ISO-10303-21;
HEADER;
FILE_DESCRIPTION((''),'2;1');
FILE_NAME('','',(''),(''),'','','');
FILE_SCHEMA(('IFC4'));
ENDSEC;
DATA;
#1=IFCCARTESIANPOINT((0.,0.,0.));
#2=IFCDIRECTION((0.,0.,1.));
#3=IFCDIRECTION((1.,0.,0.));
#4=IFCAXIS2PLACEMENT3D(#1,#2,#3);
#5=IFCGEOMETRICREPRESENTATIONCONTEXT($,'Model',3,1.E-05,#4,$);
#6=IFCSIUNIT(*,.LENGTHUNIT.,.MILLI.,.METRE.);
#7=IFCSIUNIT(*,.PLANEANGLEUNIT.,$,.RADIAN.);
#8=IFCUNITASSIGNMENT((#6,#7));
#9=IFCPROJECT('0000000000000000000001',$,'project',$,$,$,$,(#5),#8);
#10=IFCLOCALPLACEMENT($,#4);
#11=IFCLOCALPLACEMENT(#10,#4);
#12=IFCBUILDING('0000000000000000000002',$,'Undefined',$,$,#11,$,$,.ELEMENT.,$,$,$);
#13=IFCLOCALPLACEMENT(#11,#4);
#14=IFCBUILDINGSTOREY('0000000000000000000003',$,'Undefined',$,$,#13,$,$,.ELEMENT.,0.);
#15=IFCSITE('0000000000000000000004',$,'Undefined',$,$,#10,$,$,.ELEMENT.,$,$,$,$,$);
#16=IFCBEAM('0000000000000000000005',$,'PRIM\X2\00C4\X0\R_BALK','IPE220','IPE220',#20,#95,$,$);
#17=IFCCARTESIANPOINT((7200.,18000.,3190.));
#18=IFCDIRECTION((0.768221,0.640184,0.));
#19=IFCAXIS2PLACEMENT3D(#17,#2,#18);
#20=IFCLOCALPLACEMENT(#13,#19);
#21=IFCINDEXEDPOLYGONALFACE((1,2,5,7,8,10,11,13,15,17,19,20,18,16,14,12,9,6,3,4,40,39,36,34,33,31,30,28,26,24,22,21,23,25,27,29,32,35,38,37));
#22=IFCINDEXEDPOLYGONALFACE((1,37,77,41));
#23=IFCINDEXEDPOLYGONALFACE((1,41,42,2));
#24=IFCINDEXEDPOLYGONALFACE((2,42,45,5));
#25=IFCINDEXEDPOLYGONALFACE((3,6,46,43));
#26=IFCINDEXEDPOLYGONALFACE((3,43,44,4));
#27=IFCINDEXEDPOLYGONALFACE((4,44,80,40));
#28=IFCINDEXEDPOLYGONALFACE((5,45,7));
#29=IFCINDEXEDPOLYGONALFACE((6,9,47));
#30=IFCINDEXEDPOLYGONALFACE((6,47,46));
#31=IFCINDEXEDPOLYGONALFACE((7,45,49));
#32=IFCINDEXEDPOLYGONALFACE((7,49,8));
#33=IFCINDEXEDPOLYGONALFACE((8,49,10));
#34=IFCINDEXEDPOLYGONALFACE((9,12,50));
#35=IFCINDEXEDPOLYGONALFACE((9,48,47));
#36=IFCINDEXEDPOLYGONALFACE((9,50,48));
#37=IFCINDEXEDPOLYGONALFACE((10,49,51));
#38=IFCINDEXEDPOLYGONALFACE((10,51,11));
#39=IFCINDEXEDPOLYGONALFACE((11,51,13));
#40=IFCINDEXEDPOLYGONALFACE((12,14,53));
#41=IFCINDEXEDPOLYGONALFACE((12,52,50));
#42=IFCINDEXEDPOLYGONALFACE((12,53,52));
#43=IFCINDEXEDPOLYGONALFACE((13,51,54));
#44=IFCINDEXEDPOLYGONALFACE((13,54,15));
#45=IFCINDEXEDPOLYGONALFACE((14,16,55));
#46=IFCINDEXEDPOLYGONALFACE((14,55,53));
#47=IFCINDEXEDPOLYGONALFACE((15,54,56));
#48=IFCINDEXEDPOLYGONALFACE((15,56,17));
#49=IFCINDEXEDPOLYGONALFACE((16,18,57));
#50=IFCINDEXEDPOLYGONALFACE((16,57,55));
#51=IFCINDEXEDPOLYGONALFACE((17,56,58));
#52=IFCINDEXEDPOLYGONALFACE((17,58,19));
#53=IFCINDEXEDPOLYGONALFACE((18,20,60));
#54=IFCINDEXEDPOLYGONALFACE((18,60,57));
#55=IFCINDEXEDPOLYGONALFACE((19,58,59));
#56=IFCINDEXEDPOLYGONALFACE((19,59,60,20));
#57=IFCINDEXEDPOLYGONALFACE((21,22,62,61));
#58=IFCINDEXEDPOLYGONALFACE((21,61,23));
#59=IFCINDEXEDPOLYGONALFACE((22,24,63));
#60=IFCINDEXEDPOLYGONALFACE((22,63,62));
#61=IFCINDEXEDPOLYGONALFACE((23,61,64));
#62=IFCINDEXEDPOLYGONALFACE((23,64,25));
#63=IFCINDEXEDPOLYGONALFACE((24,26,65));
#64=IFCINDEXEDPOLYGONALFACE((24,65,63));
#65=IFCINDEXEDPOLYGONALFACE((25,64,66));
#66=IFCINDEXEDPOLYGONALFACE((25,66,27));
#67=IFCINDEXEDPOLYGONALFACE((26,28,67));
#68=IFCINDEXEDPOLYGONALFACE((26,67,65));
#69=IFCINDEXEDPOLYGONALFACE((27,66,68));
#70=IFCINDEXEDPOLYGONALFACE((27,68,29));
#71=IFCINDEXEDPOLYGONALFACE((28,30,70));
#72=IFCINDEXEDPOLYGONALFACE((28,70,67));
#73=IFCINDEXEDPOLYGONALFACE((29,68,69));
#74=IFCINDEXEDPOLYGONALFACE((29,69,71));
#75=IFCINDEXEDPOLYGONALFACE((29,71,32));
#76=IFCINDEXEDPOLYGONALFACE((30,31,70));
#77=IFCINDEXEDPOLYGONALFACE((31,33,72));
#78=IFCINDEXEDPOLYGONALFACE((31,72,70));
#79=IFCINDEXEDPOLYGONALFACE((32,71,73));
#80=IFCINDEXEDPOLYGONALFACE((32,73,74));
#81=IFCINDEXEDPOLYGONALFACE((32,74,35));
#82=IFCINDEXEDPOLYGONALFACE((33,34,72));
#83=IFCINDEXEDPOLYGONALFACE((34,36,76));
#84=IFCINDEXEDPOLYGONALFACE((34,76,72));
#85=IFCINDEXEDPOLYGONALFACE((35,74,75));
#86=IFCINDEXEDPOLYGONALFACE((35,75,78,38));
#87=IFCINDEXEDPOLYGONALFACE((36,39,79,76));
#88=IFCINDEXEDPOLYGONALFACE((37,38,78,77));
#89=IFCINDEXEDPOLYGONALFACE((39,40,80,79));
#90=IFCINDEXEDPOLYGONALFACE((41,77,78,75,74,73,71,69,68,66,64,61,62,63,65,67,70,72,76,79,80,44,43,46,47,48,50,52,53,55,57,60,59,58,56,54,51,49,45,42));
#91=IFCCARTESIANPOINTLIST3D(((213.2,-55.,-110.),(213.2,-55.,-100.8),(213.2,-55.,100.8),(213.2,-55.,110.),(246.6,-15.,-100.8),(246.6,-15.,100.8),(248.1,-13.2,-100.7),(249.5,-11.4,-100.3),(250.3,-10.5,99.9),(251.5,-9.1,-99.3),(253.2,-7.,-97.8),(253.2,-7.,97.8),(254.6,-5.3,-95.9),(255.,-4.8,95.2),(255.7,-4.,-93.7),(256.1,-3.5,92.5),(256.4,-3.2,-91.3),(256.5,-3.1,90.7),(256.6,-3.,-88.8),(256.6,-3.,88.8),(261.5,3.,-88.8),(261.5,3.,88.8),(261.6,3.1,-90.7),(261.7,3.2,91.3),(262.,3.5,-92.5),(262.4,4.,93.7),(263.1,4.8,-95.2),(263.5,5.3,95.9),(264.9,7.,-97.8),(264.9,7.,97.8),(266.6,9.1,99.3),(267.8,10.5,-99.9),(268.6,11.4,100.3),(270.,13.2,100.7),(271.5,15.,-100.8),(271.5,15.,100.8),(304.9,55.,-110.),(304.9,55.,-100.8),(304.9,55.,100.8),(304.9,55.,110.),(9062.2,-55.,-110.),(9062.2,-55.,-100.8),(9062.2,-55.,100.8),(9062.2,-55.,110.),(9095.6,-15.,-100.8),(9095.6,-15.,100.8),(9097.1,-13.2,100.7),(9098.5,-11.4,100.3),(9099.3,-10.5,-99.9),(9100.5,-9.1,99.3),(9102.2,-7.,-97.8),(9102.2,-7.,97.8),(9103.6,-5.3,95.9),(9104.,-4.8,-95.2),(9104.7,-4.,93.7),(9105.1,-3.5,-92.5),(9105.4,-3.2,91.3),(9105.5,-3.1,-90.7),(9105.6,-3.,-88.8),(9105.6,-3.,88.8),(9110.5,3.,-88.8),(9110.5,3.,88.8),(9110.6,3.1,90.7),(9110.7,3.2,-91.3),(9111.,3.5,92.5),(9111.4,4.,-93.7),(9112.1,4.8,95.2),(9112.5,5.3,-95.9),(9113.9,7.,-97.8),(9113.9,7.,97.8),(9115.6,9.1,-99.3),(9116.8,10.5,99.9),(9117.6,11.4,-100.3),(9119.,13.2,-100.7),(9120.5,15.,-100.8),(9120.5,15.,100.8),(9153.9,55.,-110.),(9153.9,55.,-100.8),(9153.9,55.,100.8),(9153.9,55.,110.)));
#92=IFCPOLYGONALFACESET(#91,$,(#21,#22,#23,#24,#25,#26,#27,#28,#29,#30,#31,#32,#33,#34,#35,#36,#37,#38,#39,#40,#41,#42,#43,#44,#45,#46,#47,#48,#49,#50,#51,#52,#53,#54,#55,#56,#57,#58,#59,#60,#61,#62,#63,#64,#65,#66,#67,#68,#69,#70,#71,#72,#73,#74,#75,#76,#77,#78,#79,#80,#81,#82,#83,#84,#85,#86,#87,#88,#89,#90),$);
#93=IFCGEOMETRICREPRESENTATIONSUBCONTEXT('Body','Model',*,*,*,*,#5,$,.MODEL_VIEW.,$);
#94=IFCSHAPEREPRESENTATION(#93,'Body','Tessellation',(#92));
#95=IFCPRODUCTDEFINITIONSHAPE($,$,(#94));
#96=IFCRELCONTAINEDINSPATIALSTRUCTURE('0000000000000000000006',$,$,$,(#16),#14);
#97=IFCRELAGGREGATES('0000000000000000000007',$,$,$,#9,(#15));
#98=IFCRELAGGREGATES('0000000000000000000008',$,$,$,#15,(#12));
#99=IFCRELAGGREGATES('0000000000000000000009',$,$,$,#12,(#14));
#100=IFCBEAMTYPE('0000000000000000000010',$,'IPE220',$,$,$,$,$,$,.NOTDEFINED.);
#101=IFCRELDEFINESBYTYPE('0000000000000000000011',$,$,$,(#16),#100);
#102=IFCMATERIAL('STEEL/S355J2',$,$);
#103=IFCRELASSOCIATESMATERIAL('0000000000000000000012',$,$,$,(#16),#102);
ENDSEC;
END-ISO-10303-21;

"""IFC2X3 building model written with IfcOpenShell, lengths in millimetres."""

from ifc_helpers import new_model, si_unit, frame, origin_with_axes, origin_2d_with_axis, place, context, subcontext, project, spatial, i_section, extrude, clip, halfspace, material, type_object, element, save


model = new_model("IFC2X3")

# Units and contexts
model_context = context("Model", 3, precision=1e-05, world=origin_with_axes())
body_context = subcontext(model_context, "Body", "Model", "MODEL_VIEW")
ifc_project = project(units=[si_unit("LENGTHUNIT", "METRE", prefix="MILLI"), si_unit("PLANEANGLEUNIT", "RADIAN")], contexts=[model_context])

# Site, building, storey
site_placement = place(None, origin_with_axes())
site = spatial("IfcSite", under=ifc_project, at=site_placement, Name="Undefined", CompositionType="ELEMENT")
building_placement = place(site_placement, origin_with_axes())
building = spatial("IfcBuilding", under=site, at=building_placement, Name="Undefined", CompositionType="ELEMENT")
storey_placement = place(building_placement, origin_with_axes())
storey = spatial("IfcBuildingStorey", under=building, at=storey_placement, Name="Undefined", CompositionType="ELEMENT", Elevation=0.0)

# Shared definitions
ifc_material_1 = material(Name="STEEL/S355J2")

# Beam
beam_type_1 = type_object("IfcBeamType", Name="IPE220", PredefinedType="NOTDEFINED")
beam_1_placement = place(storey_placement, frame((7200.0, 18000.0, 3190.0), z_axis=(0.0, 0.0, 1.0), x_axis=(0.768221, 0.640184, 0.0)))
element("IfcBeam", 1, at=beam_1_placement, inside=storey, type_object=beam_type_1, material=ifc_material_1, Name="PRIMÄR_BALK", Description="IPE220", ObjectType="IPE220", context=body_context, shape_type="Clipping", body=[
    clip(clip(extrude(i_section(OverallWidth=110.0, OverallDepth=220.0, WebThickness=5.9, FlangeThickness=9.2, FilletRadius=12.0, at=origin_2d_with_axis()), frame((9200.6, 0.0, 0.0), z_axis=(-1.0, 0.0, 0.0), x_axis=(0.0, -1.0, 0.0)), (0.0, 0.0, 1.0), 9034.2), halfspace(frame((9108.1, 0.0, 1110.0), z_axis=(0.768221, -0.640184, 0.0), x_axis=(0.640184, 0.768221, 0.0)), False)), halfspace(frame((259.0, 0.0, 1110.0), z_axis=(-0.768221, 0.640184, 0.0), x_axis=(-0.640184, -0.768221, 0.0)), False)),
])

save(model, "model.ifc")
